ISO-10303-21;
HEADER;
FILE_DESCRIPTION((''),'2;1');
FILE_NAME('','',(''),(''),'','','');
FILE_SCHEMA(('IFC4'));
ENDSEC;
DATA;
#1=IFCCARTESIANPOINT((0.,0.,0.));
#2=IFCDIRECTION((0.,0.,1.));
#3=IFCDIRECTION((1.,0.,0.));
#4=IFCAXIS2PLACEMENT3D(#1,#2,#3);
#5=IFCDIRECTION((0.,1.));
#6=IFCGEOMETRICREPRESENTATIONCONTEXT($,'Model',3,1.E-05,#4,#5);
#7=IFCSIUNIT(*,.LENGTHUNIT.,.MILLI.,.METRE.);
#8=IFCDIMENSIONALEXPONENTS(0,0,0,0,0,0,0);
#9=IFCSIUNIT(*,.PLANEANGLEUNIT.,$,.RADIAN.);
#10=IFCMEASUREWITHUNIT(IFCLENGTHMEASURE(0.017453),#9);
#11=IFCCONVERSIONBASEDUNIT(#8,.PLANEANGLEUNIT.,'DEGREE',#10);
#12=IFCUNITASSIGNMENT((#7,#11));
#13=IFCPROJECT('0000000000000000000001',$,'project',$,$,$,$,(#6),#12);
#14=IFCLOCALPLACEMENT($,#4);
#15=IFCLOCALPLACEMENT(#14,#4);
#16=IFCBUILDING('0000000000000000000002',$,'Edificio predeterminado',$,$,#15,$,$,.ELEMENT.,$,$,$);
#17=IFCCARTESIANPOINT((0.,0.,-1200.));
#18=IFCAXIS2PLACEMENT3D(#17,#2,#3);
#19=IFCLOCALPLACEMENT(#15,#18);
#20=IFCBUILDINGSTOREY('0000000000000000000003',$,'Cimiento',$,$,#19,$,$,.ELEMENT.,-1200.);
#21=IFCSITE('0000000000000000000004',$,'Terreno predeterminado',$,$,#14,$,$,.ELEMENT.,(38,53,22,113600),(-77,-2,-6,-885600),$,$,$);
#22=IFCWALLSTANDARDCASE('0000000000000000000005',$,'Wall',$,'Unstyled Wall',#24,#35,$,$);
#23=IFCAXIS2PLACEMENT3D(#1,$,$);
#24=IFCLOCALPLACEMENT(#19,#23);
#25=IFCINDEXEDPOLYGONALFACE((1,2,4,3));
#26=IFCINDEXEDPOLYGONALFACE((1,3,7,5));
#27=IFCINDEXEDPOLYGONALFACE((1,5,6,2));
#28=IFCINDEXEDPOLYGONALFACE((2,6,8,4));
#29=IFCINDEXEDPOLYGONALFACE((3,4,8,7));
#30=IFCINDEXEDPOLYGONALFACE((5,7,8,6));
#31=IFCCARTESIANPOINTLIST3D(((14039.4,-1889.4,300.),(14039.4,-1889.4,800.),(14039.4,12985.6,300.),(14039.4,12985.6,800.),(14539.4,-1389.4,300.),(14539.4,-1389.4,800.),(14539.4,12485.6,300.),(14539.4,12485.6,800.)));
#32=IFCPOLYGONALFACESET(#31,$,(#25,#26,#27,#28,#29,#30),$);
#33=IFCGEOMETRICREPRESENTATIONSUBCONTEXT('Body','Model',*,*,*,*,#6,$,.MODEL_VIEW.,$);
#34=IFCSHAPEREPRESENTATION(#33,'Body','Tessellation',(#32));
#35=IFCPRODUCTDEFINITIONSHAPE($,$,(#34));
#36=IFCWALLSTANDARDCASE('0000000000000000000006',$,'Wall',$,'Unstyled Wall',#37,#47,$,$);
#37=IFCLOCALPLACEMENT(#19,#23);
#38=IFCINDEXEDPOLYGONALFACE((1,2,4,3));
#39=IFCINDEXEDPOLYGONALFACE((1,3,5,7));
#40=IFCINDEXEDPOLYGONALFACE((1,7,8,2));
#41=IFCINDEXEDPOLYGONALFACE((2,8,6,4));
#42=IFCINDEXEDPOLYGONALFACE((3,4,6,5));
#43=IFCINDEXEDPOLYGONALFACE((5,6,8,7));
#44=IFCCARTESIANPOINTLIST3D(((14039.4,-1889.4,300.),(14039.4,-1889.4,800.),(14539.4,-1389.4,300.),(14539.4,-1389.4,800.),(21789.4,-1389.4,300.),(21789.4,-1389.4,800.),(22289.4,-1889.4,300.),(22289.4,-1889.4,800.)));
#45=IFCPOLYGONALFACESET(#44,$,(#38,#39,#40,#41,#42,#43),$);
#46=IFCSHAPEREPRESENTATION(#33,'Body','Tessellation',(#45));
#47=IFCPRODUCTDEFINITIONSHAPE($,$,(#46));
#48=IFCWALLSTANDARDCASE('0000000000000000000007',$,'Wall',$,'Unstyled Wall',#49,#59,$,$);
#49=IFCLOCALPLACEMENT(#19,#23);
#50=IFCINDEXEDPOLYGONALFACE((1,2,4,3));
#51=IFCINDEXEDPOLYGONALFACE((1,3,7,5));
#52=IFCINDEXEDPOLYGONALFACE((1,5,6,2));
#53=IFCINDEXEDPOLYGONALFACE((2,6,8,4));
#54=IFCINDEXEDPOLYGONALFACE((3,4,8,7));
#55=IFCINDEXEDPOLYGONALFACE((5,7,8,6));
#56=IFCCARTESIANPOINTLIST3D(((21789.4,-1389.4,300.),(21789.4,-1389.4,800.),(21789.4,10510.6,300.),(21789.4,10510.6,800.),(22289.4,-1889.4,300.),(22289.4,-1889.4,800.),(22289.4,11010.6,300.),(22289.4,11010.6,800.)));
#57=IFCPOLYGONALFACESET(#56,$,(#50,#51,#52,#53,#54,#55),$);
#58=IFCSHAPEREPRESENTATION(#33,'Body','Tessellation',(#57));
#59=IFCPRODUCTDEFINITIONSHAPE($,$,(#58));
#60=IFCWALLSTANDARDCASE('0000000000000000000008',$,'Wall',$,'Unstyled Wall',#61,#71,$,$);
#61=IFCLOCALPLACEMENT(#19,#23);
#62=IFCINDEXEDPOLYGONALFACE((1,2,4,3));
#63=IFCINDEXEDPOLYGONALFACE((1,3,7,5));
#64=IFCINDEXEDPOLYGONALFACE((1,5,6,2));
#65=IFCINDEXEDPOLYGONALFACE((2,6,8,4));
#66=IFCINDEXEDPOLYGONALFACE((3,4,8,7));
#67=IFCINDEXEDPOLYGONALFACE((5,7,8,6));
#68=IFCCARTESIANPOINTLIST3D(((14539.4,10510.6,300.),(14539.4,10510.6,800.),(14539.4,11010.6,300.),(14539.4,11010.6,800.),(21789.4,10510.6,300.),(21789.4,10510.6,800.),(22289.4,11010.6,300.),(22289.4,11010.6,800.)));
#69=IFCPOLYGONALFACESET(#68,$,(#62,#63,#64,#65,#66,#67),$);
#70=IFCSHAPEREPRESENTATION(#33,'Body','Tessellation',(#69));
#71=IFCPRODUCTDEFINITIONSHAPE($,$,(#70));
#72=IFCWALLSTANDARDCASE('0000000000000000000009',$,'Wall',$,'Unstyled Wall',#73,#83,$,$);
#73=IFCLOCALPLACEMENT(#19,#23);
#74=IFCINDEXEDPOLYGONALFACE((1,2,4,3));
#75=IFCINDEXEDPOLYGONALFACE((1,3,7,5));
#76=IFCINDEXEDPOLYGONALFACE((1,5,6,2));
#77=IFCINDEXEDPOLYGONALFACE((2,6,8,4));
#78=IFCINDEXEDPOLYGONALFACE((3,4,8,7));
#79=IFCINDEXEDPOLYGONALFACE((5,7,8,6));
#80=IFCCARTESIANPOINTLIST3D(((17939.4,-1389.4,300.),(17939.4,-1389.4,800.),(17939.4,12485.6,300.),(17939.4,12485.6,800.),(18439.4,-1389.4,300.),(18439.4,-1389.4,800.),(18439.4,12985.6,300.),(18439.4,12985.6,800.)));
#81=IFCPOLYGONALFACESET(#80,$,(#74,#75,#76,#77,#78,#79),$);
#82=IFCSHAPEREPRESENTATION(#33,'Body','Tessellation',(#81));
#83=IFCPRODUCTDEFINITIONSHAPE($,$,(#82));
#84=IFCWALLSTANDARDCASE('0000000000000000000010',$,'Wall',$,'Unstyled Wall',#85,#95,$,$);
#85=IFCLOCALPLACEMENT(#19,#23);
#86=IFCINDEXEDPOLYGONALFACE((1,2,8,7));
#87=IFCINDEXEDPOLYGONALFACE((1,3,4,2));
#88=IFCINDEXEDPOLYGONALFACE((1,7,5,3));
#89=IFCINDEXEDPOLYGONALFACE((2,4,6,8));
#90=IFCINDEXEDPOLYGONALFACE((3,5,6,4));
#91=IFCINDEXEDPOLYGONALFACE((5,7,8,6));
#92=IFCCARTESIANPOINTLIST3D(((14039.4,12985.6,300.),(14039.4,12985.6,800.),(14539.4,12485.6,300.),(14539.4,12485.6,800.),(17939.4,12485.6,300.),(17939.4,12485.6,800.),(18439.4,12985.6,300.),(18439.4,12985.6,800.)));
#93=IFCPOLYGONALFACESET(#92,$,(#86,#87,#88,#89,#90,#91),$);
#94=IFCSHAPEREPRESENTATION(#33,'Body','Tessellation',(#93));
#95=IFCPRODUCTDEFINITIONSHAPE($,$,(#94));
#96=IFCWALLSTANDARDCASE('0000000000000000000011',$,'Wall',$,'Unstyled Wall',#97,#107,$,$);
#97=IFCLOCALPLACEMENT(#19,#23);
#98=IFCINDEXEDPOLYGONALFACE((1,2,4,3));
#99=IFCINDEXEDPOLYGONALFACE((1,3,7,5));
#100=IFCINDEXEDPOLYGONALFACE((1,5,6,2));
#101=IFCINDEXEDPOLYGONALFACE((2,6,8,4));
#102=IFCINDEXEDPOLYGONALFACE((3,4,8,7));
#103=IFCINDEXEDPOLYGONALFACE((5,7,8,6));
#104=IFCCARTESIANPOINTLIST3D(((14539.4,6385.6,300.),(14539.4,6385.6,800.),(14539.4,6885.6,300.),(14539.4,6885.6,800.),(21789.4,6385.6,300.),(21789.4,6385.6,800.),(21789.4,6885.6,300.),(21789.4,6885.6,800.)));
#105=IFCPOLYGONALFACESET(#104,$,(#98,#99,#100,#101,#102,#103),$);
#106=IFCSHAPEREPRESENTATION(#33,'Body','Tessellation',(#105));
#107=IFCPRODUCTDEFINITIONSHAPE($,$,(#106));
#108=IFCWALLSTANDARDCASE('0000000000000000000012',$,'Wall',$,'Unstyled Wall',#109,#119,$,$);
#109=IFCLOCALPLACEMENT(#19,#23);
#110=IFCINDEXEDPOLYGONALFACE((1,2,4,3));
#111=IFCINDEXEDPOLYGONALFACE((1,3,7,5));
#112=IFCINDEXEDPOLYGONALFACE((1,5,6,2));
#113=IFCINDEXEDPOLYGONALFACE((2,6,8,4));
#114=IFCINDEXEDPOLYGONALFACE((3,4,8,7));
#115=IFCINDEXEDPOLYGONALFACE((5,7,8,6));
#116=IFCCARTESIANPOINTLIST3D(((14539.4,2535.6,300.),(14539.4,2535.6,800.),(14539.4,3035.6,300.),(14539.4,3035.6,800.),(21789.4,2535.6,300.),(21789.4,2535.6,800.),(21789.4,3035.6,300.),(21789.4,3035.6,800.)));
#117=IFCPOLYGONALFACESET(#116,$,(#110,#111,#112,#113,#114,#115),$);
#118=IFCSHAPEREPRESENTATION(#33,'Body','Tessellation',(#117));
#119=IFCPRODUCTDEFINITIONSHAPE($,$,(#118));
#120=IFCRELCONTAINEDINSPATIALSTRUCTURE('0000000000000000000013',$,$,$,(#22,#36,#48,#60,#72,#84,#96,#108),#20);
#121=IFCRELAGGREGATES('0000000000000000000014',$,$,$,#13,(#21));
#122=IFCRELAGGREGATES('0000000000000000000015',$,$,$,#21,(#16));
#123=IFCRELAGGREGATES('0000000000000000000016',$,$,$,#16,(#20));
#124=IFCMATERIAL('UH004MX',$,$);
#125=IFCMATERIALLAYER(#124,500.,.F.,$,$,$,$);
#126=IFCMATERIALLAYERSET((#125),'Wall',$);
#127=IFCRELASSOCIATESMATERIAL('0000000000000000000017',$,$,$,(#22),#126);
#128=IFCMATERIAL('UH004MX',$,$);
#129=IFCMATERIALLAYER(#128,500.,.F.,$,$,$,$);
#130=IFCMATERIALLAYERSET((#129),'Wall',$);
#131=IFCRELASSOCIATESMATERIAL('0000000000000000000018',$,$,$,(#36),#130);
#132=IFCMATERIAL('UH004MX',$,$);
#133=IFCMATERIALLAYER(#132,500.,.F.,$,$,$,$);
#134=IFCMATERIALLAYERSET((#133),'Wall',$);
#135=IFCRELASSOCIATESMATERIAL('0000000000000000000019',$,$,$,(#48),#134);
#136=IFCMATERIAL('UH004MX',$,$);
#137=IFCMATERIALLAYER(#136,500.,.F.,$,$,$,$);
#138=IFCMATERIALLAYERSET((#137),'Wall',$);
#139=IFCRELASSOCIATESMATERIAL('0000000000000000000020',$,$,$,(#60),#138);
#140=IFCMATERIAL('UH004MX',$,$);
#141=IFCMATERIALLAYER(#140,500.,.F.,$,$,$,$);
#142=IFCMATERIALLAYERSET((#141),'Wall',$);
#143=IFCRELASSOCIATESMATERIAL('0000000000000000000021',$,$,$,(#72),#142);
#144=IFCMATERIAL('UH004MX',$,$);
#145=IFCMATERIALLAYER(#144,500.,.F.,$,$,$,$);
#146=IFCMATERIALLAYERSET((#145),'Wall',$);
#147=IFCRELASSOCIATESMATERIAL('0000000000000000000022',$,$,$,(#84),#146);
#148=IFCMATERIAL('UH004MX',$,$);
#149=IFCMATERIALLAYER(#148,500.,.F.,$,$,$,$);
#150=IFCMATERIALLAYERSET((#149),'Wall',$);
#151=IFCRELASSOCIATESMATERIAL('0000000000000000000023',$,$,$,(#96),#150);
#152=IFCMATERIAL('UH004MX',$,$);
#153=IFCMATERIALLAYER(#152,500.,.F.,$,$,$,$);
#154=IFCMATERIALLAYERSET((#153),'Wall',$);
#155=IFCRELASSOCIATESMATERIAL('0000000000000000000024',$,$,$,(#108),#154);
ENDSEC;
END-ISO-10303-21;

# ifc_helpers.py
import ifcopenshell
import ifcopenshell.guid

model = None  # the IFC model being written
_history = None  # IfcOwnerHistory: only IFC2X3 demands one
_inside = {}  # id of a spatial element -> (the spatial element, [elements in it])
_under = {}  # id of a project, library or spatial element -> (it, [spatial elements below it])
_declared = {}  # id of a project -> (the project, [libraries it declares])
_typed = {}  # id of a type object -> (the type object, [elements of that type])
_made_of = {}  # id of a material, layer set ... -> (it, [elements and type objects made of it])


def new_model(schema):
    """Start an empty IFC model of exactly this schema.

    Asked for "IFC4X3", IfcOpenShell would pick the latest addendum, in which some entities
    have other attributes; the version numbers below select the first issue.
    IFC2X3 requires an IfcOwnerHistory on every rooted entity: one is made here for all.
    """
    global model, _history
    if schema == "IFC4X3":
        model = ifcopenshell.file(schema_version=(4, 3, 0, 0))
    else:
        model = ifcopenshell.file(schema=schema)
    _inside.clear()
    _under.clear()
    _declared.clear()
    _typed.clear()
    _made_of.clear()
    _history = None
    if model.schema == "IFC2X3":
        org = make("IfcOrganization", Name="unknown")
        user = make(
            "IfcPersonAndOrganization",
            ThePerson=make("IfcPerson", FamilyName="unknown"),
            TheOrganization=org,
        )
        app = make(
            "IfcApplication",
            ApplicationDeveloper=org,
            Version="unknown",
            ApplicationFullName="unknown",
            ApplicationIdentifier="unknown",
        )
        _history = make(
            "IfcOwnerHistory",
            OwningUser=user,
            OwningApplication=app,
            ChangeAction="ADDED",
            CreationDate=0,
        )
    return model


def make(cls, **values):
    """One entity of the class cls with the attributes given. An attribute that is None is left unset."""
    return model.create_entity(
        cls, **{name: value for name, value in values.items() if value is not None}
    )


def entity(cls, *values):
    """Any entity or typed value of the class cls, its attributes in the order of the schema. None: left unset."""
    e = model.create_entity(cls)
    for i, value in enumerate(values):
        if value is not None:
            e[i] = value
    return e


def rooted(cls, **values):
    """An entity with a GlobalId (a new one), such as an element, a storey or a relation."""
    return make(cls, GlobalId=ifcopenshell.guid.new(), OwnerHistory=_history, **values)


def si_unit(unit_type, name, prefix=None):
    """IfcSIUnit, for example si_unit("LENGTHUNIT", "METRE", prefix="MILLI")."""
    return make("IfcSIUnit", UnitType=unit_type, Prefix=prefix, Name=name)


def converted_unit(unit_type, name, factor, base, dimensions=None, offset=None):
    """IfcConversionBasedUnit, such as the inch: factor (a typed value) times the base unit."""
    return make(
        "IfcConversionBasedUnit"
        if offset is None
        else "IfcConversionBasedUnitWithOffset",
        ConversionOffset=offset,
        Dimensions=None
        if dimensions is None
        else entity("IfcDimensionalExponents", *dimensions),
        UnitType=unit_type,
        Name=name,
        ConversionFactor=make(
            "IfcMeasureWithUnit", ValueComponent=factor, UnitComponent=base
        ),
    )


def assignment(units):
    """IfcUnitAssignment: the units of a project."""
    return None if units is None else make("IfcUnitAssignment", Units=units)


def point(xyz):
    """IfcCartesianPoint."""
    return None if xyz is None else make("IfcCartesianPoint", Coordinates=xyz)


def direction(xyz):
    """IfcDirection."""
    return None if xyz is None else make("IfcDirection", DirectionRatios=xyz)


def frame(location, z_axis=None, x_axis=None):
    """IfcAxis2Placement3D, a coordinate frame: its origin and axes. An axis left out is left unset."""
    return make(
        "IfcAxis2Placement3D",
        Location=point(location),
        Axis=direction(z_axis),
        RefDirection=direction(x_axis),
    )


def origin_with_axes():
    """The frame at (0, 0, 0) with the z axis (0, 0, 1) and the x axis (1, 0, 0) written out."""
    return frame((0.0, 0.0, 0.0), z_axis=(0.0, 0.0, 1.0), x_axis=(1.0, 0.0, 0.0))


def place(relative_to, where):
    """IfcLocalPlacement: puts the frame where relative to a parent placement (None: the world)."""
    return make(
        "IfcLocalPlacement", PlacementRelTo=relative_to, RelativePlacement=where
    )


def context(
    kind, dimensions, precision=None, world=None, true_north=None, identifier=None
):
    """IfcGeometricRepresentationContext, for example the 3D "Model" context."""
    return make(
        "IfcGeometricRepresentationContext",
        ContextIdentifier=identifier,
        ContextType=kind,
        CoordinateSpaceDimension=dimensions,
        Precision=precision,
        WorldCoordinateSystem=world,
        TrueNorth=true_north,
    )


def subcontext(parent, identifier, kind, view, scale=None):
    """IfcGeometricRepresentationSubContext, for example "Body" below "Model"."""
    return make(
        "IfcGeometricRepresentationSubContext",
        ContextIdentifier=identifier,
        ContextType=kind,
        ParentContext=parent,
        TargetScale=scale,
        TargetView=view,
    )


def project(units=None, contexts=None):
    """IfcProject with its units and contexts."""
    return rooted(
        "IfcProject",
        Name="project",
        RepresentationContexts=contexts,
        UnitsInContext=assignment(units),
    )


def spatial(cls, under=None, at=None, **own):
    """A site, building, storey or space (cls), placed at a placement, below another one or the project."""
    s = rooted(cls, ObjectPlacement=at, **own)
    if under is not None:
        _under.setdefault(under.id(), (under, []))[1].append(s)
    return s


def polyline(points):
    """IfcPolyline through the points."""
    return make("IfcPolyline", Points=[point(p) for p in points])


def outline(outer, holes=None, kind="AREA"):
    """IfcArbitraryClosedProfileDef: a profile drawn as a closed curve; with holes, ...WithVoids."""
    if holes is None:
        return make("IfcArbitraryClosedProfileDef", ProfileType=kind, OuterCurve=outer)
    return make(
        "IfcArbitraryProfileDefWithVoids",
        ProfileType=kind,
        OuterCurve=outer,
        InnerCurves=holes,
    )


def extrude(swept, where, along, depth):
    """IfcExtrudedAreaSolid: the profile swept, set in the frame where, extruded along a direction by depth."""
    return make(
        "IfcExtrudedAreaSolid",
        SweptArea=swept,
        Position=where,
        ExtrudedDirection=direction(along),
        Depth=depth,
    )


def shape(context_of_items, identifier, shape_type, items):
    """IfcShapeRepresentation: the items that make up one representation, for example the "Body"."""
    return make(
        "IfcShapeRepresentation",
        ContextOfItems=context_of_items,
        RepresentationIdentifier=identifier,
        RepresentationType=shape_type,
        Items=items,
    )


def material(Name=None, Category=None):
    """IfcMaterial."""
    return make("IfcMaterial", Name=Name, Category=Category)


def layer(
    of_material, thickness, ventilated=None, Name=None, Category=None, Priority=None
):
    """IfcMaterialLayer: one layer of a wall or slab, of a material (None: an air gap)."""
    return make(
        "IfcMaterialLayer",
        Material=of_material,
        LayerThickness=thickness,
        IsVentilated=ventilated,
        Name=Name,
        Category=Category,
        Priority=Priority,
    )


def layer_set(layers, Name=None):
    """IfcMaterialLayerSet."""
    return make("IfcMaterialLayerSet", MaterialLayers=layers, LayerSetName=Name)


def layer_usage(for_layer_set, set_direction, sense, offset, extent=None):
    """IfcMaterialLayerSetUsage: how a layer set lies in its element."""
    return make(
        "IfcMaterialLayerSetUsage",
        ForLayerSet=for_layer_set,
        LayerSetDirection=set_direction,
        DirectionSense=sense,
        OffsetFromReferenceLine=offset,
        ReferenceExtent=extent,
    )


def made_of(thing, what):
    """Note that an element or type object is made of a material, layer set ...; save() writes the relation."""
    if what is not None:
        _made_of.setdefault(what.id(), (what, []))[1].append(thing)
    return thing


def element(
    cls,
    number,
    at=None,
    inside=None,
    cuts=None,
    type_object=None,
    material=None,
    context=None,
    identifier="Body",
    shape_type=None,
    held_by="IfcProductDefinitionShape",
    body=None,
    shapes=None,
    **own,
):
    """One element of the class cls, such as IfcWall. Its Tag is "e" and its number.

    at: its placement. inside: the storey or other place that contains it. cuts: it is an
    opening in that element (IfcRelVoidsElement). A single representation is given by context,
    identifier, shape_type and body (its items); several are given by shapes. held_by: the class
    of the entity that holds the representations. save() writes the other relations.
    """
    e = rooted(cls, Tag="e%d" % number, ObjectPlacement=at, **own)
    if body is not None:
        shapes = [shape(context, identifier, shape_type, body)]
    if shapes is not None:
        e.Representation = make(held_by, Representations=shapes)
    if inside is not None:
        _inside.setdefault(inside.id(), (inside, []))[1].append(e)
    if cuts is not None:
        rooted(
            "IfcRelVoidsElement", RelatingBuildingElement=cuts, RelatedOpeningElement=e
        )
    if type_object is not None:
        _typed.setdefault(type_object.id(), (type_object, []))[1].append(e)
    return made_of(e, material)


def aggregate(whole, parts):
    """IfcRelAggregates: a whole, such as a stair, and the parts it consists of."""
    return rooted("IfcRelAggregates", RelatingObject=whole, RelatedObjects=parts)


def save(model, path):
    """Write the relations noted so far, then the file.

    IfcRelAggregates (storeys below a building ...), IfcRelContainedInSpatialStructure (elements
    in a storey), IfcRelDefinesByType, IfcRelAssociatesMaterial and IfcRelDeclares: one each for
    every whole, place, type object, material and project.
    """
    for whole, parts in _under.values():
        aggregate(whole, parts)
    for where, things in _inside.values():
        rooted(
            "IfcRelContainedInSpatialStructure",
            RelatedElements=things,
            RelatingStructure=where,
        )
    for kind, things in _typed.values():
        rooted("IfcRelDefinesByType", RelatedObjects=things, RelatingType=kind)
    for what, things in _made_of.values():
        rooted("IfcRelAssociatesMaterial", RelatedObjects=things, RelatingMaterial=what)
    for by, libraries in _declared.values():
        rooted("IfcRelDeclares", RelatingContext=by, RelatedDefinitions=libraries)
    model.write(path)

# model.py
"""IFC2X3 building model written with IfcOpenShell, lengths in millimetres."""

from ifc_helpers import new_model, entity, si_unit, converted_unit, direction, frame, origin_with_axes, place, context, subcontext, project, spatial, polyline, outline, extrude, material, layer, layer_set, layer_usage, element, save


model = new_model("IFC2X3")

# Units and contexts
model_context = context("Model", 3, precision=1e-05, world=origin_with_axes(), true_north=direction((0.0, 1.0)))
body_context = subcontext(model_context, "Body", "Model", "MODEL_VIEW")
ifc_project = project(units=[si_unit("LENGTHUNIT", "METRE", prefix="MILLI"), converted_unit("PLANEANGLEUNIT", "DEGREE", entity("IfcLengthMeasure", 0.017453), si_unit("PLANEANGLEUNIT", "RADIAN"), dimensions=[0, 0, 0, 0, 0, 0, 0])], contexts=[model_context])

# Site, building, storey
site_placement = place(None, origin_with_axes())
site = spatial("IfcSite", under=ifc_project, at=site_placement, Name="Terreno predeterminado", CompositionType="ELEMENT", RefLatitude=(38, 53, 22, 113600), RefLongitude=(-77, -2, -6, -885600))
building_placement = place(site_placement, origin_with_axes())
building = spatial("IfcBuilding", under=site, at=building_placement, Name="Edificio predeterminado", CompositionType="ELEMENT")
storey_placement = place(building_placement, frame((0.0, 0.0, -1200.0), z_axis=(0.0, 0.0, 1.0), x_axis=(1.0, 0.0, 0.0)))
storey = spatial("IfcBuildingStorey", under=building, at=storey_placement, Name="Cimiento", CompositionType="ELEMENT", Elevation=-1200.0)

# Walls
ifc_material_1 = material(Name="UH004MX")
ifc_layer_1 = layer(ifc_material_1, 500.0, ventilated=False)
ifc_layer_set_1 = layer_set([ifc_layer_1], Name="Wall")
ifc_layer_usage_1 = layer_usage(ifc_layer_set_1, "AXIS2", "POSITIVE", -250.0)
wall_1_placement = place(storey_placement, frame((14289.4, 12735.6, 300.0), z_axis=(0.0, 0.0, 1.0), x_axis=(0.0, -1.0, 0.0)))
element("IfcWallStandardCase", 1, at=wall_1_placement, inside=storey, material=ifc_layer_usage_1, Name="Wall", ObjectType="Unstyled Wall", context=body_context, shape_type="SweptSolid", body=[
    extrude(outline(polyline([(250.0, 250.0), (-250.0, -250.0), (14625.0, -250.0), (14125.0, 250.0), (250.0, 250.0)])), origin_with_axes(), (0.0, 0.0, 1.0), 500.0),
])
ifc_material_2 = material(Name="UH004MX")
ifc_layer_2 = layer(ifc_material_2, 500.0, ventilated=False)
ifc_layer_set_2 = layer_set([ifc_layer_2], Name="Wall")
ifc_layer_usage_2 = layer_usage(ifc_layer_set_2, "AXIS2", "POSITIVE", -250.0)
wall_2_placement = place(storey_placement, frame((14289.4, -1639.4, 300.0), z_axis=(0.0, 0.0, 1.0), x_axis=(1.0, 0.0, 0.0)))
element("IfcWallStandardCase", 2, at=wall_2_placement, inside=storey, material=ifc_layer_usage_2, Name="Wall", ObjectType="Unstyled Wall", context=body_context, shape_type="SweptSolid", body=[
    extrude(outline(polyline([(-250.0, -250.0), (250.0, 250.0), (7500.0, 250.0), (8000.0, -250.0), (-250.0, -250.0)])), origin_with_axes(), (0.0, 0.0, 1.0), 500.0),
])
ifc_material_3 = material(Name="UH004MX")
ifc_layer_3 = layer(ifc_material_3, 500.0, ventilated=False)
ifc_layer_set_3 = layer_set([ifc_layer_3], Name="Wall")
ifc_layer_usage_3 = layer_usage(ifc_layer_set_3, "AXIS2", "POSITIVE", -250.0)
wall_3_placement = place(storey_placement, frame((22039.4, -1639.4, 300.0), z_axis=(0.0, 0.0, 1.0), x_axis=(0.0, 1.0, 0.0)))
element("IfcWallStandardCase", 3, at=wall_3_placement, inside=storey, material=ifc_layer_usage_3, Name="Wall", ObjectType="Unstyled Wall", context=body_context, shape_type="SweptSolid", body=[
    extrude(outline(polyline([(-250.0, -250.0), (250.0, 250.0), (12150.0, 250.0), (12650.0, -250.0), (-250.0, -250.0)])), origin_with_axes(), (0.0, 0.0, 1.0), 500.0),
])
ifc_material_4 = material(Name="UH004MX")
ifc_layer_4 = layer(ifc_material_4, 500.0, ventilated=False)
ifc_layer_set_4 = layer_set([ifc_layer_4], Name="Wall")
ifc_layer_usage_4 = layer_usage(ifc_layer_set_4, "AXIS2", "POSITIVE", -250.0)
wall_4_placement = place(storey_placement, frame((22039.4, 10760.6, 300.0), z_axis=(0.0, 0.0, 1.0), x_axis=(-1.0, 0.0, 0.0)))
element("IfcWallStandardCase", 4, at=wall_4_placement, inside=storey, material=ifc_layer_usage_4, Name="Wall", ObjectType="Unstyled Wall", context=body_context, shape_type="SweptSolid", body=[
    extrude(outline(polyline([(-250.0, -250.0), (250.0, 250.0), (7500.0, 250.0), (7500.0, -250.0), (-250.0, -250.0)])), origin_with_axes(), (0.0, 0.0, 1.0), 500.0),
])
ifc_material_5 = material(Name="UH004MX")
ifc_layer_5 = layer(ifc_material_5, 500.0, ventilated=False)
ifc_layer_set_5 = layer_set([ifc_layer_5], Name="Wall")
ifc_layer_usage_5 = layer_usage(ifc_layer_set_5, "AXIS2", "POSITIVE", -250.0)
wall_5_placement = place(storey_placement, frame((18189.4, -1639.4, 300.0), z_axis=(0.0, 0.0, 1.0), x_axis=(0.0, 1.0, 0.0)))
element("IfcWallStandardCase", 5, at=wall_5_placement, inside=storey, material=ifc_layer_usage_5, Name="Wall", ObjectType="Unstyled Wall", context=body_context, shape_type="SweptSolid", body=[
    extrude(outline(polyline([(250.0, 250.0), (250.0, -250.0), (14625.0, -250.0), (14125.0, 250.0), (250.0, 250.0)])), origin_with_axes(), (0.0, 0.0, 1.0), 500.0),
])
ifc_material_6 = material(Name="UH004MX")
ifc_layer_6 = layer(ifc_material_6, 500.0, ventilated=False)
ifc_layer_set_6 = layer_set([ifc_layer_6], Name="Wall")
ifc_layer_usage_6 = layer_usage(ifc_layer_set_6, "AXIS2", "POSITIVE", -250.0)
wall_6_placement = place(storey_placement, frame((18189.4, 12735.6, 300.0), z_axis=(0.0, 0.0, 1.0), x_axis=(-1.0, 0.0, 0.0)))
element("IfcWallStandardCase", 6, at=wall_6_placement, inside=storey, material=ifc_layer_usage_6, Name="Wall", ObjectType="Unstyled Wall", context=body_context, shape_type="SweptSolid", body=[
    extrude(outline(polyline([(-250.0, -250.0), (250.0, 250.0), (3650.0, 250.0), (4150.0, -250.0), (-250.0, -250.0)])), origin_with_axes(), (0.0, 0.0, 1.0), 500.0),
])
ifc_material_7 = material(Name="UH004MX")
ifc_layer_7 = layer(ifc_material_7, 500.0, ventilated=False)
ifc_layer_set_7 = layer_set([ifc_layer_7], Name="Wall")
ifc_layer_usage_7 = layer_usage(ifc_layer_set_7, "AXIS2", "POSITIVE", -250.0)
wall_7_placement = place(storey_placement, frame((14289.4, 6635.6, 300.0), z_axis=(0.0, 0.0, 1.0), x_axis=(1.0, 0.0, 0.0)))
element("IfcWallStandardCase", 7, at=wall_7_placement, inside=storey, material=ifc_layer_usage_7, Name="Wall", ObjectType="Unstyled Wall", context=body_context, shape_type="SweptSolid", body=[
    extrude(outline(polyline([(250.0, -250.0), (250.0, 250.0), (7500.0, 250.0), (7500.0, -250.0), (250.0, -250.0)])), origin_with_axes(), (0.0, 0.0, 1.0), 500.0),
])
ifc_material_8 = material(Name="UH004MX")
ifc_layer_8 = layer(ifc_material_8, 500.0, ventilated=False)
ifc_layer_set_8 = layer_set([ifc_layer_8], Name="Wall")
ifc_layer_usage_8 = layer_usage(ifc_layer_set_8, "AXIS2", "POSITIVE", -250.0)
wall_8_placement = place(storey_placement, frame((14289.4, 2785.6, 300.0), z_axis=(0.0, 0.0, 1.0), x_axis=(1.0, 0.0, 0.0)))
element("IfcWallStandardCase", 8, at=wall_8_placement, inside=storey, material=ifc_layer_usage_8, Name="Wall", ObjectType="Unstyled Wall", context=body_context, shape_type="SweptSolid", body=[
    extrude(outline(polyline([(250.0, -250.0), (250.0, 250.0), (7500.0, 250.0), (7500.0, -250.0), (250.0, -250.0)])), origin_with_axes(), (0.0, 0.0, 1.0), 500.0),
])

save(model, "model.ifc")
